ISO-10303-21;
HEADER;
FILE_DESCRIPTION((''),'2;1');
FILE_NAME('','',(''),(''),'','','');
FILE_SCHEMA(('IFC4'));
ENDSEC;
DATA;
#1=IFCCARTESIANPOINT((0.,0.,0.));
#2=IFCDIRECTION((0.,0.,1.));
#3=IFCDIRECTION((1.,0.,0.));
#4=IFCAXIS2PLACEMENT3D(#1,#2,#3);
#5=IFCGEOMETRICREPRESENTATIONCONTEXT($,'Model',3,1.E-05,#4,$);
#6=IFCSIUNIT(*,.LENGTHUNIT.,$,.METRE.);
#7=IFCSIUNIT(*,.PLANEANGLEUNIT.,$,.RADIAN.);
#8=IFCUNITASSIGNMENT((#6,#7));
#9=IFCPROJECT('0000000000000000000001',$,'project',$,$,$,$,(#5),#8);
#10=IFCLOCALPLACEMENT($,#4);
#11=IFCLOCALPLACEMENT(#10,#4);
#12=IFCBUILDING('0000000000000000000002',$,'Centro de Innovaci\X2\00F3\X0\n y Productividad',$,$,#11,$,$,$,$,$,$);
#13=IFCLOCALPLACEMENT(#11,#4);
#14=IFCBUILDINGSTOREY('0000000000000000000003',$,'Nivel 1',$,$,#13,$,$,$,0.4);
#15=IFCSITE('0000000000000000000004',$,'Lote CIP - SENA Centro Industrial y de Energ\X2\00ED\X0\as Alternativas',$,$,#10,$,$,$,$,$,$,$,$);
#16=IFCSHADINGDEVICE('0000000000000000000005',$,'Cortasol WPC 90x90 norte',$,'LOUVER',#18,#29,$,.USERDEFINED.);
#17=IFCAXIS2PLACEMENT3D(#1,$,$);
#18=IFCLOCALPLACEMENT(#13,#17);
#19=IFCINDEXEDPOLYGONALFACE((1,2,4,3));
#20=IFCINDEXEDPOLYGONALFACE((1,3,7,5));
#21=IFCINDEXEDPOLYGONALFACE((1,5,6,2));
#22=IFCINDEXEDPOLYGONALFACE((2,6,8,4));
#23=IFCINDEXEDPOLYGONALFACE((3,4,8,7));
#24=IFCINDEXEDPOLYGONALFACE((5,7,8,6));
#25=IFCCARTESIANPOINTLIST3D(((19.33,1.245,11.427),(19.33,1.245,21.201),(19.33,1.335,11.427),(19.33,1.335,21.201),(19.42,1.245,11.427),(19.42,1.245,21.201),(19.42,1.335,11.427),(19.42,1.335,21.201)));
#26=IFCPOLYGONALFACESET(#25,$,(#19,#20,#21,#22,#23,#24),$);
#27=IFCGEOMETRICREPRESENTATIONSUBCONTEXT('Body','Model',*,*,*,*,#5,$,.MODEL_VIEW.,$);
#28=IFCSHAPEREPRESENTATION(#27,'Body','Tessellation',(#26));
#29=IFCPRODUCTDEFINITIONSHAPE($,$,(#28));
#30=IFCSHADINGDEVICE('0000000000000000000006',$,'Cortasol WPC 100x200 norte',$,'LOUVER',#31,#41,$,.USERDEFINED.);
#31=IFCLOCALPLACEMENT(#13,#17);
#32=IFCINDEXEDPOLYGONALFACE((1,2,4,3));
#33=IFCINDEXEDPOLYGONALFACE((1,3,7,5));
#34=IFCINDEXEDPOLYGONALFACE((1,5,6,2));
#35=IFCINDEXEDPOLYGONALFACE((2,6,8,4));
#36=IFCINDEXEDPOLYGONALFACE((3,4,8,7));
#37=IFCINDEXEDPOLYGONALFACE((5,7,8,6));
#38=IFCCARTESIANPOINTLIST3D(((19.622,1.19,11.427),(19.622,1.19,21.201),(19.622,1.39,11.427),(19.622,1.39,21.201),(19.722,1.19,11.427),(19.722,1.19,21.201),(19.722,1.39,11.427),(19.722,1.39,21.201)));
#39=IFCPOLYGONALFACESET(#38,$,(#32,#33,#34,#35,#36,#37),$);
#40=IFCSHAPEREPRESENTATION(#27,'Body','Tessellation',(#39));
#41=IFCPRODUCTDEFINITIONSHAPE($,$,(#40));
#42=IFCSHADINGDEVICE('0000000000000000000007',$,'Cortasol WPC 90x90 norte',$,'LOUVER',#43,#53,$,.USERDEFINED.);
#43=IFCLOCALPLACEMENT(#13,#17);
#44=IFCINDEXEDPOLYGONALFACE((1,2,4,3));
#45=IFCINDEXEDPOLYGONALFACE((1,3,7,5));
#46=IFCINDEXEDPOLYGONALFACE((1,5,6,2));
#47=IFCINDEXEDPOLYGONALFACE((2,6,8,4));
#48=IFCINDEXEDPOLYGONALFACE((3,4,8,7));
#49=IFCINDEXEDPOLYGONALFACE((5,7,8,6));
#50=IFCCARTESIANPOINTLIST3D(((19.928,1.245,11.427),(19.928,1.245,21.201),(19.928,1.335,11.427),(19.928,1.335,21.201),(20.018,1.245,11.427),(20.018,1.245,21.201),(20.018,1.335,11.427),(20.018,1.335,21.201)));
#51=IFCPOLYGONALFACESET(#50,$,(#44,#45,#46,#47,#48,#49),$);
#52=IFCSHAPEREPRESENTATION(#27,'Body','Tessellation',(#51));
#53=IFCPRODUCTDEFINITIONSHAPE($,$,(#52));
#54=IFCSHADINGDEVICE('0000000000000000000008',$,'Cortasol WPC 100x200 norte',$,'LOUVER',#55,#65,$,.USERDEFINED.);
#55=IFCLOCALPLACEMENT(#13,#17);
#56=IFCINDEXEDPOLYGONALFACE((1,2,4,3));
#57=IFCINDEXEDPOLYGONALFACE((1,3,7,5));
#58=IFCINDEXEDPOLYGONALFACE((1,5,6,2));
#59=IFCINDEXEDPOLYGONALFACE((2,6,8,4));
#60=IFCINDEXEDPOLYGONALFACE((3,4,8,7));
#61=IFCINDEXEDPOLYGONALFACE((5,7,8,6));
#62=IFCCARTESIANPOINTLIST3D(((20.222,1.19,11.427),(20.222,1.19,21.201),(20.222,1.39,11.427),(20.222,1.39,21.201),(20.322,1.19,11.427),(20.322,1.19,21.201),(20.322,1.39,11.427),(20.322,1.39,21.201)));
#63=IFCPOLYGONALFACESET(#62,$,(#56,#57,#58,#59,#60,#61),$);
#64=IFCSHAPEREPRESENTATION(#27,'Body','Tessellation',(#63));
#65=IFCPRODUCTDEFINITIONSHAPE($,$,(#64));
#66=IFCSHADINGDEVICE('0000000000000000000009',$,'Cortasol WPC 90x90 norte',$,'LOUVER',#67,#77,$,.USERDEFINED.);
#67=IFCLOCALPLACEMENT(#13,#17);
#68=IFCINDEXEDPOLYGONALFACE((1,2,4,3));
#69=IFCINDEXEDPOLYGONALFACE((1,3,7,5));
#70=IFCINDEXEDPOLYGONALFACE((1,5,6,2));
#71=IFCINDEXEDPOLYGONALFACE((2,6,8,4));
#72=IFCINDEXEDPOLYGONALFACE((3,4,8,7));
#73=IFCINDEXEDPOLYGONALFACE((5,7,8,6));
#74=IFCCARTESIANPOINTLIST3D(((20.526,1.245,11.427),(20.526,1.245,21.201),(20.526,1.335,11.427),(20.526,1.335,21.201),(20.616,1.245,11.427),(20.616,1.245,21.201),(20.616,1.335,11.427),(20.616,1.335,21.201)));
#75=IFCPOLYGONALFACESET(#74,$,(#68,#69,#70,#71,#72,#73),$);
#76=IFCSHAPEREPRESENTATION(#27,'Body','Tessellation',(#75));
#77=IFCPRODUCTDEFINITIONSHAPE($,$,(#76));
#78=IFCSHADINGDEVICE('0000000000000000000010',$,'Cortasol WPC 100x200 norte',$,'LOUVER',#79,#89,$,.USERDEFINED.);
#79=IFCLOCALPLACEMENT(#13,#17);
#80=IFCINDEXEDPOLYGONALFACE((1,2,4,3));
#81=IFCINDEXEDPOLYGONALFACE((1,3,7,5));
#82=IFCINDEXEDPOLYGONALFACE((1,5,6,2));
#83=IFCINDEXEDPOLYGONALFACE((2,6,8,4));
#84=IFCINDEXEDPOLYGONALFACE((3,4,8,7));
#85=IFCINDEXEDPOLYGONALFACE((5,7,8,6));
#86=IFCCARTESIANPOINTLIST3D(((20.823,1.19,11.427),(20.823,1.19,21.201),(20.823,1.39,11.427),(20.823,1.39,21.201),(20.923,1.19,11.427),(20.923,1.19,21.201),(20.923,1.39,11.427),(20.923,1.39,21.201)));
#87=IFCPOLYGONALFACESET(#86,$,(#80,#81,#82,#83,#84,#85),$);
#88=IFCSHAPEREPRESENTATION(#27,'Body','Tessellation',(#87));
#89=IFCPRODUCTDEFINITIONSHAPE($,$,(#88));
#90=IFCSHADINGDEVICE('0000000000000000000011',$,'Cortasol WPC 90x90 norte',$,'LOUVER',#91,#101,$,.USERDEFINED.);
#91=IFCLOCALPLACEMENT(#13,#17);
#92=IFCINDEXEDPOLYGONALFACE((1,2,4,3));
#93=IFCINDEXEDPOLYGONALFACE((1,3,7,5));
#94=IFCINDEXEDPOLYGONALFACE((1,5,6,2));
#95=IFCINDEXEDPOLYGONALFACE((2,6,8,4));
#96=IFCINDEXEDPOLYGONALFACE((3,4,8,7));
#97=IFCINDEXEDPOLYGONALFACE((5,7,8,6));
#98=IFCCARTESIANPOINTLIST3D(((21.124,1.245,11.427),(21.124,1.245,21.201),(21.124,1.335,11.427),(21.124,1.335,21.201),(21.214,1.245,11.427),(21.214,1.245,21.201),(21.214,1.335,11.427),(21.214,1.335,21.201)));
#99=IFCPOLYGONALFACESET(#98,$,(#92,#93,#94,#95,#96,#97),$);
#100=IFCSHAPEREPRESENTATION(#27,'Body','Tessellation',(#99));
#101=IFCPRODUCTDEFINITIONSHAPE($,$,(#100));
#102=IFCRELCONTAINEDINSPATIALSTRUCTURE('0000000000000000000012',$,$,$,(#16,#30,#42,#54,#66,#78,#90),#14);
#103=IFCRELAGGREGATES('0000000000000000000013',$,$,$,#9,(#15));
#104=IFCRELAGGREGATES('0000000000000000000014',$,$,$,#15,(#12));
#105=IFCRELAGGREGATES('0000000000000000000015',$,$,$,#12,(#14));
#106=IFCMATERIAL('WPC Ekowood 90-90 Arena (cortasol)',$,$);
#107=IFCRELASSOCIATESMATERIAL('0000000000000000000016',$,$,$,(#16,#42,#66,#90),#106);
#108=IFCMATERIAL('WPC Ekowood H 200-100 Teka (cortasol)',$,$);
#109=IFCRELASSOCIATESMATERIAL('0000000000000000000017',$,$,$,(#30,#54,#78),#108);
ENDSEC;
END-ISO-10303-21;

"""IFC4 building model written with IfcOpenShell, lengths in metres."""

from ifc_helpers import new_model, si_unit, frame, origin_with_axes, place, context, subcontext, project, spatial, polyline, outline, extrude, material, element, save


model = new_model("IFC4")

# Units and contexts
model_context = context("Model", 3, precision=1e-05, world=origin_with_axes())
body_context = subcontext(model_context, "Body", "Model", "MODEL_VIEW")
ifc_project = project(units=[si_unit("LENGTHUNIT", "METRE"), si_unit("PLANEANGLEUNIT", "RADIAN")], contexts=[model_context])

# Site, building, storey
site_placement = place(None, origin_with_axes())
site = spatial("IfcSite", under=ifc_project, at=site_placement, Name="Lote CIP - SENA Centro Industrial y de Energías Alternativas")
building_placement = place(site_placement, origin_with_axes())
building = spatial("IfcBuilding", under=site, at=building_placement, Name="Centro de Innovación y Productividad")
storey_placement = place(building_placement, origin_with_axes())
storey = spatial("IfcBuildingStorey", under=building, at=storey_placement, Name="Nivel 1", Elevation=0.4)

# Shading devices
ifc_material_1 = material(Name="WPC Ekowood H 200-100 Teka (cortasol)")
ifc_material_2 = material(Name="WPC Ekowood 90-90 Arena (cortasol)")
shading_device_1_placement = place(storey_placement, origin_with_axes())
element("IfcShadingDevice", 1, at=shading_device_1_placement, inside=storey, material=ifc_material_2, Name="Cortasol WPC 90x90 norte", ObjectType="LOUVER", PredefinedType="USERDEFINED", context=body_context, shape_type="SweptSolid", body=[
    extrude(outline(polyline([(19.33, 1.245), (19.33, 1.335), (19.42, 1.335), (19.42, 1.245), (19.33, 1.245)])), frame((0.0, 0.0, 11.427)), (0.0, 0.0, 1.0), 9.774),
])
shading_device_2_placement = place(storey_placement, origin_with_axes())
element("IfcShadingDevice", 2, at=shading_device_2_placement, inside=storey, material=ifc_material_1, Name="Cortasol WPC 100x200 norte", ObjectType="LOUVER", PredefinedType="USERDEFINED", context=body_context, shape_type="SweptSolid", body=[
    extrude(outline(polyline([(19.622, 1.19), (19.622, 1.39), (19.722, 1.39), (19.722, 1.19), (19.622, 1.19)])), frame((0.0, 0.0, 11.427)), (0.0, 0.0, 1.0), 9.774),
])
shading_device_3_placement = place(storey_placement, origin_with_axes())
element("IfcShadingDevice", 3, at=shading_device_3_placement, inside=storey, material=ifc_material_2, Name="Cortasol WPC 90x90 norte", ObjectType="LOUVER", PredefinedType="USERDEFINED", context=body_context, shape_type="SweptSolid", body=[
    extrude(outline(polyline([(19.928, 1.245), (19.928, 1.335), (20.018, 1.335), (20.018, 1.245), (19.928, 1.245)])), frame((0.0, 0.0, 11.427)), (0.0, 0.0, 1.0), 9.774),
])
shading_device_4_placement = place(storey_placement, origin_with_axes())
element("IfcShadingDevice", 4, at=shading_device_4_placement, inside=storey, material=ifc_material_1, Name="Cortasol WPC 100x200 norte", ObjectType="LOUVER", PredefinedType="USERDEFINED", context=body_context, shape_type="SweptSolid", body=[
    extrude(outline(polyline([(20.222, 1.19), (20.222, 1.39), (20.322, 1.39), (20.322, 1.19), (20.222, 1.19)])), frame((0.0, 0.0, 11.427)), (0.0, 0.0, 1.0), 9.774),
])
shading_device_5_placement = place(storey_placement, origin_with_axes())
element("IfcShadingDevice", 5, at=shading_device_5_placement, inside=storey, material=ifc_material_2, Name="Cortasol WPC 90x90 norte", ObjectType="LOUVER", PredefinedType="USERDEFINED", context=body_context, shape_type="SweptSolid", body=[
    extrude(outline(polyline([(20.526, 1.245), (20.526, 1.335), (20.616, 1.335), (20.616, 1.245), (20.526, 1.245)])), frame((0.0, 0.0, 11.427)), (0.0, 0.0, 1.0), 9.774),
])
shading_device_6_placement = place(storey_placement, origin_with_axes())
element("IfcShadingDevice", 6, at=shading_device_6_placement, inside=storey, material=ifc_material_1, Name="Cortasol WPC 100x200 norte", ObjectType="LOUVER", PredefinedType="USERDEFINED", context=body_context, shape_type="SweptSolid", body=[
    extrude(outline(polyline([(20.823, 1.19), (20.823, 1.39), (20.923, 1.39), (20.923, 1.19), (20.823, 1.19)])), frame((0.0, 0.0, 11.427)), (0.0, 0.0, 1.0), 9.774),
])
shading_device_7_placement = place(storey_placement, origin_with_axes())
element("IfcShadingDevice", 7, at=shading_device_7_placement, inside=storey, material=ifc_material_2, Name="Cortasol WPC 90x90 norte", ObjectType="LOUVER", PredefinedType="USERDEFINED", context=body_context, shape_type="SweptSolid", body=[
    extrude(outline(polyline([(21.124, 1.245), (21.124, 1.335), (21.214, 1.335), (21.214, 1.245), (21.124, 1.245)])), frame((0.0, 0.0, 11.427)), (0.0, 0.0, 1.0), 9.774),
])

save(model, "model.ifc")
